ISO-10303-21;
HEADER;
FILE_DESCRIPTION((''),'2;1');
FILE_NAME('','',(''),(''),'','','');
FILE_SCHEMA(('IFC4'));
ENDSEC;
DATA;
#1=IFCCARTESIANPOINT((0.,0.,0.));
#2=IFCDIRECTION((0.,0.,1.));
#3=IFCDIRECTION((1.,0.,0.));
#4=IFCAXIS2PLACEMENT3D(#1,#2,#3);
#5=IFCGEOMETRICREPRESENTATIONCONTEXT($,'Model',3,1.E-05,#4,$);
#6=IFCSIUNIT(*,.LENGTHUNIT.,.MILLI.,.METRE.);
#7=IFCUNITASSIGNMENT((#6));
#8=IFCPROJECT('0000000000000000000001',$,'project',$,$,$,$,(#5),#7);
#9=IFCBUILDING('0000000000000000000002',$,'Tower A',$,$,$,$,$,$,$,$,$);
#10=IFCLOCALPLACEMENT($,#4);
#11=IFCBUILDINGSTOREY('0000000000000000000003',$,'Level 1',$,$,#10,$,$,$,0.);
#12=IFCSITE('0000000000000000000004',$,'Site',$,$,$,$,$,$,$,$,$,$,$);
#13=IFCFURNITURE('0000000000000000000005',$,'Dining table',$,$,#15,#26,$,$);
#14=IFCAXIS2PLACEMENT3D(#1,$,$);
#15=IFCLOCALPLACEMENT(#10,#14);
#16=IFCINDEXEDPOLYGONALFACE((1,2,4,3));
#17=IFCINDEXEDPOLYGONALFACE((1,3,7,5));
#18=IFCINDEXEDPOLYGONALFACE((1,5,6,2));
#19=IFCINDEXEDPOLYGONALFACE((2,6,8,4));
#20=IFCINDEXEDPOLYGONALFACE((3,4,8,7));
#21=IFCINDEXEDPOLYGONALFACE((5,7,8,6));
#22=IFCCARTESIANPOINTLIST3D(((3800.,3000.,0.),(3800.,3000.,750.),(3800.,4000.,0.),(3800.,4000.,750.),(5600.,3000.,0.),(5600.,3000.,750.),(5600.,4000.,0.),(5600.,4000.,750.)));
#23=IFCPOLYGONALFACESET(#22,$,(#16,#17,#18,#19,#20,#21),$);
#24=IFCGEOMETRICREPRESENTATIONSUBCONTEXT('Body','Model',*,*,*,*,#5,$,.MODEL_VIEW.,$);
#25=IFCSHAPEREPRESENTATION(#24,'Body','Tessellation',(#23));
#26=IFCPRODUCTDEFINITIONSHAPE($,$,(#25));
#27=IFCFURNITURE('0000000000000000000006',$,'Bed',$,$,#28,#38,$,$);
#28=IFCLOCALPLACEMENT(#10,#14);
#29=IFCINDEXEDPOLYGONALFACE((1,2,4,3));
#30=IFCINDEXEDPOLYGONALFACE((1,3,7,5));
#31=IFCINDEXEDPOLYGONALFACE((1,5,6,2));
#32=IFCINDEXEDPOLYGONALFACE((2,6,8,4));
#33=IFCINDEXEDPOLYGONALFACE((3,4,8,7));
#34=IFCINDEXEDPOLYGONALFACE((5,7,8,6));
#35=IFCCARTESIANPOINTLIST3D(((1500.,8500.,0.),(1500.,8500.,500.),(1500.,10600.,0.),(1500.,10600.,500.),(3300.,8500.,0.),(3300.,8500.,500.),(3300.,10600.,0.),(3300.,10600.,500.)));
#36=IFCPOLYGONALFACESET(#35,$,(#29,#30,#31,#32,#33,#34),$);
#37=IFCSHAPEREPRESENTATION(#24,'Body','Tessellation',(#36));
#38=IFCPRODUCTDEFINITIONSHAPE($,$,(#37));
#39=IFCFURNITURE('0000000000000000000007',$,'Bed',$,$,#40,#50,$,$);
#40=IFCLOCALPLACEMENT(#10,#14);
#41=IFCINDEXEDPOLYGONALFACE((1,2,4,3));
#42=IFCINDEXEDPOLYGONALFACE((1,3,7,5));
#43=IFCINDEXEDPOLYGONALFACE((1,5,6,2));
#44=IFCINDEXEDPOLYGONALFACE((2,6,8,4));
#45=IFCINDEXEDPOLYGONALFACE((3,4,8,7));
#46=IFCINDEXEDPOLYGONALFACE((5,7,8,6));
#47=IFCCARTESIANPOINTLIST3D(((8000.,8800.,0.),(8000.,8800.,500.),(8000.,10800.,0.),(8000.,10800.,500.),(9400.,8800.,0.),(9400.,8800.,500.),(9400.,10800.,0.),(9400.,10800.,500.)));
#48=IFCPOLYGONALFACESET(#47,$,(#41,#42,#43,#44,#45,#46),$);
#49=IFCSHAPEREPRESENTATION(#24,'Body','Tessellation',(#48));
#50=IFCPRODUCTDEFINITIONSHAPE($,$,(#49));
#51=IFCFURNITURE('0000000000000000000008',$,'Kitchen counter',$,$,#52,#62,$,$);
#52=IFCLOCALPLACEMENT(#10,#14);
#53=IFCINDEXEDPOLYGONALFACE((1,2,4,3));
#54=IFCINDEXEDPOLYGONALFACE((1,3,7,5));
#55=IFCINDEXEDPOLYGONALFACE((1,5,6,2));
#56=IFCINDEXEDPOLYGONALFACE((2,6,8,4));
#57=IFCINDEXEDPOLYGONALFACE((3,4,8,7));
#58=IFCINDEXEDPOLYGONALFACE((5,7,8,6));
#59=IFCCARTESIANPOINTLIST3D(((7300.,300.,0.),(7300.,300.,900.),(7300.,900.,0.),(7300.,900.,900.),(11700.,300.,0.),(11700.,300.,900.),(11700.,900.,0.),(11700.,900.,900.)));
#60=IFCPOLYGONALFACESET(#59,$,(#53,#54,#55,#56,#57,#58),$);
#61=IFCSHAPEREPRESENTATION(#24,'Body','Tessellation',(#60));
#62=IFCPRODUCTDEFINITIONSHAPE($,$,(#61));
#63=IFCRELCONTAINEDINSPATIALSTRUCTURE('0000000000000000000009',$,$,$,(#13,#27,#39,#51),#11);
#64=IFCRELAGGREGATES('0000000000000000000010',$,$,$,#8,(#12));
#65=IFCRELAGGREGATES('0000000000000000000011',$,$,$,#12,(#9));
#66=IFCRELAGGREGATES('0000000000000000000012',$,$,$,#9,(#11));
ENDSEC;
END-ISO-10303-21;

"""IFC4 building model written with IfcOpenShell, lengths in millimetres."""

from ifc_helpers import new_model, si_unit, frame, origin_with_axes, place, context, subcontext, project, spatial, indexed_curve, outline, extrude, element, save


model = new_model("IFC4")

# Units and contexts
model_context = context("Model", 3, precision=1e-05, world=origin_with_axes())
body_context = subcontext(model_context, "Body", "Model", "MODEL_VIEW")
ifc_project = project(units=[si_unit("LENGTHUNIT", "METRE", prefix="MILLI")], contexts=[model_context])

# Site, building, storey
site = spatial("IfcSite", under=ifc_project, Name="Site")
building = spatial("IfcBuilding", under=site, Name="Tower A")
storey_placement = place(None, origin_with_axes())
storey = spatial("IfcBuildingStorey", under=building, at=storey_placement, Name="Level 1", Elevation=0.0)

# Furniture
furniture_1_placement = place(storey_placement, frame((3800.0, 3000.0, 0.0), z_axis=(0.0, 0.0, 1.0), x_axis=(1.0, 0.0, 0.0)))
element("IfcFurniture", 1, at=furniture_1_placement, inside=storey, Name="Dining table", context=body_context, shape_type="SweptSolid", body=[
    extrude(outline(indexed_curve([(0.0, 0.0), (1800.0, 0.0), (1800.0, 1000.0), (0.0, 1000.0)])), None, (0.0, 0.0, 1.0), 750.0),
])
furniture_2_placement = place(storey_placement, frame((1500.0, 8500.0, 0.0), z_axis=(0.0, 0.0, 1.0), x_axis=(1.0, 0.0, 0.0)))
element("IfcFurniture", 2, at=furniture_2_placement, inside=storey, Name="Bed", context=body_context, shape_type="SweptSolid", body=[
    extrude(outline(indexed_curve([(0.0, 0.0), (1800.0, 0.0), (1800.0, 2100.0), (0.0, 2100.0)])), None, (0.0, 0.0, 1.0), 500.0),
])
furniture_3_placement = place(storey_placement, frame((8000.0, 8800.0, 0.0), z_axis=(0.0, 0.0, 1.0), x_axis=(1.0, 0.0, 0.0)))
element("IfcFurniture", 3, at=furniture_3_placement, inside=storey, Name="Bed", context=body_context, shape_type="SweptSolid", body=[
    extrude(outline(indexed_curve([(0.0, 0.0), (1400.0, 0.0), (1400.0, 2000.0), (0.0, 2000.0)])), None, (0.0, 0.0, 1.0), 500.0),
])
furniture_4_placement = place(storey_placement, frame((7300.0, 300.0, 0.0), z_axis=(0.0, 0.0, 1.0), x_axis=(1.0, 0.0, 0.0)))
element("IfcFurniture", 4, at=furniture_4_placement, inside=storey, Name="Kitchen counter", context=body_context, shape_type="SweptSolid", body=[
    extrude(outline(indexed_curve([(0.0, 0.0), (4400.0, 0.0), (4400.0, 600.0), (0.0, 600.0)])), None, (0.0, 0.0, 1.0), 900.0),
])

save(model, "model.ifc")
